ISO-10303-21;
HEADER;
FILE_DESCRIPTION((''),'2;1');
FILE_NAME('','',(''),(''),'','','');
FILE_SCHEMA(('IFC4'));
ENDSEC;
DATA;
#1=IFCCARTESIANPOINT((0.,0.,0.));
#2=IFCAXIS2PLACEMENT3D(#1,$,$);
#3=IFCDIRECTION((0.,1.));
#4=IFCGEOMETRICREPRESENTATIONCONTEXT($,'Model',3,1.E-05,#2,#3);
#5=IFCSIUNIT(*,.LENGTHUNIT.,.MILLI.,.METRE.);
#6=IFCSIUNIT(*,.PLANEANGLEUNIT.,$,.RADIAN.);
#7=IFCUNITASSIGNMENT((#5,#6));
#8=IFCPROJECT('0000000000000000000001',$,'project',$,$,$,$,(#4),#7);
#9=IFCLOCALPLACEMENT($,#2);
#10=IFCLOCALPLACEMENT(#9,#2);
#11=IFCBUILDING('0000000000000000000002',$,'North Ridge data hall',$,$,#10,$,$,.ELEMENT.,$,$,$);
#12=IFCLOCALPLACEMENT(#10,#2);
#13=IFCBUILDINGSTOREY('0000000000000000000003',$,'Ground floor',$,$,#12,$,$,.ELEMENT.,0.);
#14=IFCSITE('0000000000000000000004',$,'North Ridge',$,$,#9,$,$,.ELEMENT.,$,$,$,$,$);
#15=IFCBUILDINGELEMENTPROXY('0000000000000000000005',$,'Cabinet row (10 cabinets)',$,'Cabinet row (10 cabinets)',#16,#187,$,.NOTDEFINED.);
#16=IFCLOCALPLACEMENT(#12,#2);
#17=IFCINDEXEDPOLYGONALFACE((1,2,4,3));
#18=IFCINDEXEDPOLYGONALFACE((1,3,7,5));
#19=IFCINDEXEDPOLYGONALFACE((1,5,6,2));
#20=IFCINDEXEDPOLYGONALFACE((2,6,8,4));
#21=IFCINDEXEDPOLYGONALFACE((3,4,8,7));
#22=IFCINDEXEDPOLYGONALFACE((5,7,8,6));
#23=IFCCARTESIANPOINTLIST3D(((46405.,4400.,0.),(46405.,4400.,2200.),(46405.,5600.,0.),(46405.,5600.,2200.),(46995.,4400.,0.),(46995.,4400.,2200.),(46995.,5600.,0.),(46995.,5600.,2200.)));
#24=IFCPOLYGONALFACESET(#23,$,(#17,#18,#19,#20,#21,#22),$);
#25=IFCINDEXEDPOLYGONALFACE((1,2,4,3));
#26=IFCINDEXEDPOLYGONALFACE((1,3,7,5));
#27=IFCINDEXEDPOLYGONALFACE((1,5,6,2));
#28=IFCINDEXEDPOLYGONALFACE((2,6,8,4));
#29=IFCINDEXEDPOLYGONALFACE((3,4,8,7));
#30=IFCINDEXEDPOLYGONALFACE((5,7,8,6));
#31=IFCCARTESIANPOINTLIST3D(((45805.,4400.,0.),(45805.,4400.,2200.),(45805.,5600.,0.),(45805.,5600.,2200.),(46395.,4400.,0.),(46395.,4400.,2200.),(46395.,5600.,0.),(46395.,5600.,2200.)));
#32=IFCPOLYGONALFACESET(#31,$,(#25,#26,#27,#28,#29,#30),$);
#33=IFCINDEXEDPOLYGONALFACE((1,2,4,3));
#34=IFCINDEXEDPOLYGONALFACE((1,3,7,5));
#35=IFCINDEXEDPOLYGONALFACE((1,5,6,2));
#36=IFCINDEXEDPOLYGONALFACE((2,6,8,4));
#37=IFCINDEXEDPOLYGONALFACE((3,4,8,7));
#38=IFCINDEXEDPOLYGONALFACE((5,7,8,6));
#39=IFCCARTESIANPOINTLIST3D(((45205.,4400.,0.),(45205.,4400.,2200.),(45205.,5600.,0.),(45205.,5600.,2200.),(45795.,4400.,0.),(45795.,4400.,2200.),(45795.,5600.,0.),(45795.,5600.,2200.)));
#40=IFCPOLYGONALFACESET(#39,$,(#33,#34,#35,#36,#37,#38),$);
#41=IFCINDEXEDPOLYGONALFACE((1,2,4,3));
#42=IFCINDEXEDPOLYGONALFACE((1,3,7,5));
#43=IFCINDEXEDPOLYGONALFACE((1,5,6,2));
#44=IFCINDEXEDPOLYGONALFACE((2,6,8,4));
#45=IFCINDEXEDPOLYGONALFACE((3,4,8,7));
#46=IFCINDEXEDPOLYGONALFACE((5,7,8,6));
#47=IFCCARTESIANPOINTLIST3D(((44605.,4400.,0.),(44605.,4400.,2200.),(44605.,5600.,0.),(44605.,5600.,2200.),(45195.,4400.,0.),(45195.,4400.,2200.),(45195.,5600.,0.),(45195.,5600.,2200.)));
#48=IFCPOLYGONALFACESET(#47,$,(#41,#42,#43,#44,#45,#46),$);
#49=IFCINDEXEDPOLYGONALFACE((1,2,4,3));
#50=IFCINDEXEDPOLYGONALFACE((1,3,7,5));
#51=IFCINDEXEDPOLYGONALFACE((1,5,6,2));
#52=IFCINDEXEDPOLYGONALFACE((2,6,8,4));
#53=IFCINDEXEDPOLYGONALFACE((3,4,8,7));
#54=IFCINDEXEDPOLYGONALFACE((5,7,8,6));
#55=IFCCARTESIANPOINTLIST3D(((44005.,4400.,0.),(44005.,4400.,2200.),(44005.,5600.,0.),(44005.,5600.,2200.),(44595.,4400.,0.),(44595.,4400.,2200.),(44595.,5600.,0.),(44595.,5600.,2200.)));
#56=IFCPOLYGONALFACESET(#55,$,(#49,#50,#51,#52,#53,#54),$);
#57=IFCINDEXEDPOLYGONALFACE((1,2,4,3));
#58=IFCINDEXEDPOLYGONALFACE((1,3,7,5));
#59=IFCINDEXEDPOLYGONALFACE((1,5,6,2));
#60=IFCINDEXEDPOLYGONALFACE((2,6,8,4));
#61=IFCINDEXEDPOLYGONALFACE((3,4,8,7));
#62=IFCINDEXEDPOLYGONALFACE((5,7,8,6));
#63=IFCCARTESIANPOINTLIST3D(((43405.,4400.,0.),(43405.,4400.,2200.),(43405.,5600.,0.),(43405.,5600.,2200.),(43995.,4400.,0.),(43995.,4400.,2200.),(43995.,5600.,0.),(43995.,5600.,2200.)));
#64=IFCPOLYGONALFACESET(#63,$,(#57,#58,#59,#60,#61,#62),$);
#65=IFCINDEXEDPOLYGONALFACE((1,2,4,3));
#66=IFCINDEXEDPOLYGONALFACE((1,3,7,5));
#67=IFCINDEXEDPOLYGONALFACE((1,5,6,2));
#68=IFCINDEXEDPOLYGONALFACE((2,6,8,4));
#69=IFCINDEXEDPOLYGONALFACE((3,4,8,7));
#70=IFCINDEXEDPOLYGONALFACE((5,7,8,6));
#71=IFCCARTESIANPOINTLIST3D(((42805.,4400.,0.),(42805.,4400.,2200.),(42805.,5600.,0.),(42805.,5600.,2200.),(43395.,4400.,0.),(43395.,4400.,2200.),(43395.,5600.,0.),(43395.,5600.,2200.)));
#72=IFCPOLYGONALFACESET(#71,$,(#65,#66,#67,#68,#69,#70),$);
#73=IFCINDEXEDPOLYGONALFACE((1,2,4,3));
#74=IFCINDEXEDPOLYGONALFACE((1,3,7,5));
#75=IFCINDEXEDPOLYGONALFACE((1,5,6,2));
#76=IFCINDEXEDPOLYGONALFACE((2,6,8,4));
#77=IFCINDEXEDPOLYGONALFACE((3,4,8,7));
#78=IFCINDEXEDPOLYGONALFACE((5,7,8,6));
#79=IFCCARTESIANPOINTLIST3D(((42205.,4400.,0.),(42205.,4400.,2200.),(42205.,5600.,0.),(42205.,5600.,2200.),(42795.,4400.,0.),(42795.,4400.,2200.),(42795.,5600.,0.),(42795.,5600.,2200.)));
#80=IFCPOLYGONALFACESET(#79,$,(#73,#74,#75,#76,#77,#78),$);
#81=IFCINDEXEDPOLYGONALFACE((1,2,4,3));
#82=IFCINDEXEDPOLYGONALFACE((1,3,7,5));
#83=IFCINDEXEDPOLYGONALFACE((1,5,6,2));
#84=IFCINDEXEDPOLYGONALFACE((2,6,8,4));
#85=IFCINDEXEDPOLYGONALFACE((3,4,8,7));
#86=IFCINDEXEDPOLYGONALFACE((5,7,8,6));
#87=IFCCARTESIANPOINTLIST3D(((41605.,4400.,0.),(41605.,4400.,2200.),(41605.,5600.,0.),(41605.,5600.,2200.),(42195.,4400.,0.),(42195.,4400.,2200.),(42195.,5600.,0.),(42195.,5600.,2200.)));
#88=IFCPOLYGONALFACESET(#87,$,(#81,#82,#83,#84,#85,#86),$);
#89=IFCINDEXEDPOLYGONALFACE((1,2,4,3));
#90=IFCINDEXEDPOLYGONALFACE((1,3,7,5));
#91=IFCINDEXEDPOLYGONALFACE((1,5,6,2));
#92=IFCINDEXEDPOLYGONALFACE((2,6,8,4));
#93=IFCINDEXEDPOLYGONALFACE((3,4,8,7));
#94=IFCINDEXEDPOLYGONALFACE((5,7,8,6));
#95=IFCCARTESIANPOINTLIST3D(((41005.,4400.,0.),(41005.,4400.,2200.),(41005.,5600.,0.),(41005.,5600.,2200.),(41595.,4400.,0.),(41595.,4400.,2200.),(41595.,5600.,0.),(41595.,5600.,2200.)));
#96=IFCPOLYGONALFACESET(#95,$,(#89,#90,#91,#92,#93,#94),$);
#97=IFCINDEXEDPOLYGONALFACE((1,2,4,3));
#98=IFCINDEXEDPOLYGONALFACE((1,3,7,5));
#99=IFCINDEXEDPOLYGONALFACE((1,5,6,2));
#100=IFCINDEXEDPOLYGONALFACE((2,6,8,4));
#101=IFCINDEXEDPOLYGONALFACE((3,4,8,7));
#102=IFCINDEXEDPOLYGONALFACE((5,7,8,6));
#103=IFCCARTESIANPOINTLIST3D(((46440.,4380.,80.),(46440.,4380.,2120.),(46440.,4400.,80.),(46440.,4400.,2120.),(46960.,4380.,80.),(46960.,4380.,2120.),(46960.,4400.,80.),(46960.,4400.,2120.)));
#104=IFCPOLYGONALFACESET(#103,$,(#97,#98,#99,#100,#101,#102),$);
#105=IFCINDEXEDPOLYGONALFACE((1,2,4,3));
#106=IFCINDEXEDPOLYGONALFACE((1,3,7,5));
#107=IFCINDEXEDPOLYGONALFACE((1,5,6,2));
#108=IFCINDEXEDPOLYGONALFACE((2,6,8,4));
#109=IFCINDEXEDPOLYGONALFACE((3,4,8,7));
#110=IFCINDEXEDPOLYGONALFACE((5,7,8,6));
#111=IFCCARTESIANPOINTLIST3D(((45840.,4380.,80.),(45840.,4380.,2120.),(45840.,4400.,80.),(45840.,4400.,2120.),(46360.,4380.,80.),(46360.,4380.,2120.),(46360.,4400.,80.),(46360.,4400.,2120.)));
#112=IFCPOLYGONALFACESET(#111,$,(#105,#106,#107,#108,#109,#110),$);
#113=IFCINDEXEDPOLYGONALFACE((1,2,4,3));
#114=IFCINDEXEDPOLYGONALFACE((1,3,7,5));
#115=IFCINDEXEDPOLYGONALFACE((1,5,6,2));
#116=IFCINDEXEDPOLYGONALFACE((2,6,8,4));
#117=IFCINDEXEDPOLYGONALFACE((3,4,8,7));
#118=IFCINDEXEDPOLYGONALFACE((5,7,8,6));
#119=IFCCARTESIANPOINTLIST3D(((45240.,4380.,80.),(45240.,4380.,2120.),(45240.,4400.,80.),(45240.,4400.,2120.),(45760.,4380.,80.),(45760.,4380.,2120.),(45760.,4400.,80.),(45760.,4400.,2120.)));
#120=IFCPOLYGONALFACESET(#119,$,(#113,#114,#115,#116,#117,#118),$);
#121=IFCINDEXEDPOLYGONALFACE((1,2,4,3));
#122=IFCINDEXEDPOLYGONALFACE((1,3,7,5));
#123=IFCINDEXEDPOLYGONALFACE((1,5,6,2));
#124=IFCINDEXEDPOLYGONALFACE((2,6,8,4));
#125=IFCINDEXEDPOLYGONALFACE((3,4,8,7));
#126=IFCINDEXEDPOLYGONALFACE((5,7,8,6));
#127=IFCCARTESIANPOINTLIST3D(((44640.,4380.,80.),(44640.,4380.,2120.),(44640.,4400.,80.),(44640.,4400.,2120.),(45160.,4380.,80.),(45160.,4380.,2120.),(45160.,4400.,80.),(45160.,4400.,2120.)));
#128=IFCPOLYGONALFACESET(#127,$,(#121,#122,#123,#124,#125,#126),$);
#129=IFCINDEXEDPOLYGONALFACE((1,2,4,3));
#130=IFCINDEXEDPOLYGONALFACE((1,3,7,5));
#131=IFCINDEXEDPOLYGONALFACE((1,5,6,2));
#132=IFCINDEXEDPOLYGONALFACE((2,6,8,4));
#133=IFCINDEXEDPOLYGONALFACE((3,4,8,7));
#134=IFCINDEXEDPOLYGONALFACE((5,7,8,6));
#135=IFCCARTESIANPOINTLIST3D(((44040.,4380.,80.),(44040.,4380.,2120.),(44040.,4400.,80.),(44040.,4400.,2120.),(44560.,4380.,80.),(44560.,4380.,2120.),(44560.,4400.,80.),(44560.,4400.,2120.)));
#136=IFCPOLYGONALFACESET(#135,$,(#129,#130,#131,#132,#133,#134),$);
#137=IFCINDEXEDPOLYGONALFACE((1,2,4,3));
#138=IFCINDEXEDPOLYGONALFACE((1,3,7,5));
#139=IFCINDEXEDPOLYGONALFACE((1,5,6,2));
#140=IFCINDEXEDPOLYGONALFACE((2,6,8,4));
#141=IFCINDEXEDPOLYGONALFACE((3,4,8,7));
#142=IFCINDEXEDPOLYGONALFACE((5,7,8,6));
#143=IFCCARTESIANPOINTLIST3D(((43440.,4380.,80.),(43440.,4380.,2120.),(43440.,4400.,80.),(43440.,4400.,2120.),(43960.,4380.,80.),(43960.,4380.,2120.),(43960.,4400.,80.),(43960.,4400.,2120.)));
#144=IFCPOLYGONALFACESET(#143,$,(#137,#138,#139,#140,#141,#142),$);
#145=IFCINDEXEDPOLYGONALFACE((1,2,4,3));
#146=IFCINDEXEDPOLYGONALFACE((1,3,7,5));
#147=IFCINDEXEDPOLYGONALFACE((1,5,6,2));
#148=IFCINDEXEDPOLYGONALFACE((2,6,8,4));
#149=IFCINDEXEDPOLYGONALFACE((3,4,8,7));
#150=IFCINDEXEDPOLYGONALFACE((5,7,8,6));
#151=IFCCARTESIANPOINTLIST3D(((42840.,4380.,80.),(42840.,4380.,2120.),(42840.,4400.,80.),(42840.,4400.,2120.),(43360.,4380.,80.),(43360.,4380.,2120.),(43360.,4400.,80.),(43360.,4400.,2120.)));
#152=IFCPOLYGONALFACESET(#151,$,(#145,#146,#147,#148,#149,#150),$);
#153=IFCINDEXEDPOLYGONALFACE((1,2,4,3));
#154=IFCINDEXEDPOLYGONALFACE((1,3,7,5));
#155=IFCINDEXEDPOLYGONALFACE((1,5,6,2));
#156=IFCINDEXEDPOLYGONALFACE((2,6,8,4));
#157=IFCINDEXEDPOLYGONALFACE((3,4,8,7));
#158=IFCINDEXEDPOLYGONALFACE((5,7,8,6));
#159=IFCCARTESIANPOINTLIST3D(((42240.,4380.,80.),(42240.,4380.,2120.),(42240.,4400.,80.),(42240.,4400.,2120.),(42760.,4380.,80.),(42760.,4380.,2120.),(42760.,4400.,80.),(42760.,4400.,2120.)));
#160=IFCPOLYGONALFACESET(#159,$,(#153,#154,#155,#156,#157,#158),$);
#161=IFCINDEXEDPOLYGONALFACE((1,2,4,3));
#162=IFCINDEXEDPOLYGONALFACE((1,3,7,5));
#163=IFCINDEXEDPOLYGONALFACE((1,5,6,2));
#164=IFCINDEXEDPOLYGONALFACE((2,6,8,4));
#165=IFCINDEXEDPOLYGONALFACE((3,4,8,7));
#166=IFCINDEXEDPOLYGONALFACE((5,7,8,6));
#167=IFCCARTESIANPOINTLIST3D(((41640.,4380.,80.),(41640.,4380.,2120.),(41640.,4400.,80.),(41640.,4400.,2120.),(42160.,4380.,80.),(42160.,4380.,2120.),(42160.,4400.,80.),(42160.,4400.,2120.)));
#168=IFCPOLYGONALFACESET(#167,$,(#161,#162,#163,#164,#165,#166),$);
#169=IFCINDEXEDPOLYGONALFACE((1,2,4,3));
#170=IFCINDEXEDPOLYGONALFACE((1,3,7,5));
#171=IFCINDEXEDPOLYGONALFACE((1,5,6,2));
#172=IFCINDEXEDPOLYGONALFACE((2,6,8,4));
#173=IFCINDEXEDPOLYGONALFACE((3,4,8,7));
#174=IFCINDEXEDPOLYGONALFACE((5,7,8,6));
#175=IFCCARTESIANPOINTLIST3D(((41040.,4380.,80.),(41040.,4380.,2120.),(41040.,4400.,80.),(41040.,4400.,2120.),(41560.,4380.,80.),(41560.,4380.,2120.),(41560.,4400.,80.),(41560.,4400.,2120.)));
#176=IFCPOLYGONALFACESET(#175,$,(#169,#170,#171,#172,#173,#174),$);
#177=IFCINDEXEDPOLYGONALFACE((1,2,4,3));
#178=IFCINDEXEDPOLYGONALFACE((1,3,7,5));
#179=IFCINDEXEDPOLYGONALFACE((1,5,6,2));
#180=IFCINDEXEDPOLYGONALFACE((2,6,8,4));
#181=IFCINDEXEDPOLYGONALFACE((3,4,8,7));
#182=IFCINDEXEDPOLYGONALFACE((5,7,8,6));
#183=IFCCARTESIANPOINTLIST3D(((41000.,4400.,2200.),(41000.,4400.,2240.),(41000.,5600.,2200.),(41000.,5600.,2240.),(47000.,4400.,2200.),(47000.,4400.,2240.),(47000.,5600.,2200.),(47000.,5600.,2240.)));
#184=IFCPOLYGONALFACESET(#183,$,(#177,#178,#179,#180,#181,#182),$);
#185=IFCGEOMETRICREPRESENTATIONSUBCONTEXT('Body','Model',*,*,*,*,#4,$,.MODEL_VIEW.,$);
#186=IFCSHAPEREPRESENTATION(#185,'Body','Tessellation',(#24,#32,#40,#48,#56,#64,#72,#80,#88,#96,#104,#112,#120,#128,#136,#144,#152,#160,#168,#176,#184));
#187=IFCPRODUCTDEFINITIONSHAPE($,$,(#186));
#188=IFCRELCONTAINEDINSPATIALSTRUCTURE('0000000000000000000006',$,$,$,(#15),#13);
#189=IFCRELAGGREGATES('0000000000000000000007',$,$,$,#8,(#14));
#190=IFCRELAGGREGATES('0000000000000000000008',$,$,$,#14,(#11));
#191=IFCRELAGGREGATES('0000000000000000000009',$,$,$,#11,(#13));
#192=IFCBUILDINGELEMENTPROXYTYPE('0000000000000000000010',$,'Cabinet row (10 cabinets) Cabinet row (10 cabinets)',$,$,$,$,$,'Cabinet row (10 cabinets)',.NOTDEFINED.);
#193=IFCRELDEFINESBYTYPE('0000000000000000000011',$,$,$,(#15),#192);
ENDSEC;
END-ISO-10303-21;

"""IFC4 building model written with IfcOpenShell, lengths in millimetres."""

from ifc_helpers import new_model, si_unit, direction, frame, origin, place, context, subcontext, project, spatial, polyline, outline, extrude, source, transform, mapped, type_object, type_shapes, element, save


model = new_model("IFC4")

# Units and contexts
model_context = context("Model", 3, precision=1e-05, world=origin(), true_north=direction((0.0, 1.0)))
body_context = subcontext(model_context, "Body", "Model", "MODEL_VIEW")
ifc_project = project(units=[si_unit("LENGTHUNIT", "METRE", prefix="MILLI"), si_unit("PLANEANGLEUNIT", "RADIAN")], contexts=[model_context])

# Site, building, storey
site_placement = place(None, origin())
site = spatial("IfcSite", under=ifc_project, at=site_placement, Name="North Ridge", CompositionType="ELEMENT")
building_placement = place(site_placement, origin())
building = spatial("IfcBuilding", under=site, at=building_placement, Name="North Ridge data hall", CompositionType="ELEMENT")
storey_placement = place(building_placement, origin())
storey = spatial("IfcBuildingStorey", under=building, at=storey_placement, Name="Ground floor", CompositionType="ELEMENT", Elevation=0.0)

# Building element proxy
building_element_proxy_type_1 = type_object("IfcBuildingElementProxyType", Name="Cabinet row (10 cabinets) Cabinet row (10 cabinets)", ElementType="Cabinet row (10 cabinets)", PredefinedType="NOTDEFINED")
shared_shape_1 = source(origin(), body_context, "Body", "SweptSolid", [
    extrude(outline(polyline([(5.0, 0.0), (595.0, 0.0), (595.0, 1200.0), (5.0, 1200.0), (5.0, 0.0)])), origin(), (0.0, 0.0, 1.0), 2200.0),
    extrude(outline(polyline([(605.0, 0.0), (1195.0, 0.0), (1195.0, 1200.0), (605.0, 1200.0), (605.0, 0.0)])), origin(), (0.0, 0.0, 1.0), 2200.0),
    extrude(outline(polyline([(1205.0, 0.0), (1795.0, 0.0), (1795.0, 1200.0), (1205.0, 1200.0), (1205.0, 0.0)])), origin(), (0.0, 0.0, 1.0), 2200.0),
    extrude(outline(polyline([(1805.0, 0.0), (2395.0, 0.0), (2395.0, 1200.0), (1805.0, 1200.0), (1805.0, 0.0)])), origin(), (0.0, 0.0, 1.0), 2200.0),
    extrude(outline(polyline([(2405.0, 0.0), (2995.0, 0.0), (2995.0, 1200.0), (2405.0, 1200.0), (2405.0, 0.0)])), origin(), (0.0, 0.0, 1.0), 2200.0),
    extrude(outline(polyline([(3005.0, 0.0), (3595.0, 0.0), (3595.0, 1200.0), (3005.0, 1200.0), (3005.0, 0.0)])), origin(), (0.0, 0.0, 1.0), 2200.0),
    extrude(outline(polyline([(3605.0, 0.0), (4195.0, 0.0), (4195.0, 1200.0), (3605.0, 1200.0), (3605.0, 0.0)])), origin(), (0.0, 0.0, 1.0), 2200.0),
    extrude(outline(polyline([(4205.0, 0.0), (4795.0, 0.0), (4795.0, 1200.0), (4205.0, 1200.0), (4205.0, 0.0)])), origin(), (0.0, 0.0, 1.0), 2200.0),
    extrude(outline(polyline([(4805.0, 0.0), (5395.0, 0.0), (5395.0, 1200.0), (4805.0, 1200.0), (4805.0, 0.0)])), origin(), (0.0, 0.0, 1.0), 2200.0),
    extrude(outline(polyline([(5405.0, 0.0), (5995.0, 0.0), (5995.0, 1200.0), (5405.0, 1200.0), (5405.0, 0.0)])), origin(), (0.0, 0.0, 1.0), 2200.0),
    extrude(outline(polyline([(40.0, 1200.0), (560.0, 1200.0), (560.0, 1220.0), (40.0, 1220.0), (40.0, 1200.0)])), frame((0.0, 0.0, 80.0)), (0.0, 0.0, 1.0), 2040.0),
    extrude(outline(polyline([(640.0, 1200.0), (1160.0, 1200.0), (1160.0, 1220.0), (640.0, 1220.0), (640.0, 1200.0)])), frame((0.0, 0.0, 80.0)), (0.0, 0.0, 1.0), 2040.0),
    extrude(outline(polyline([(1240.0, 1200.0), (1760.0, 1200.0), (1760.0, 1220.0), (1240.0, 1220.0), (1240.0, 1200.0)])), frame((0.0, 0.0, 80.0)), (0.0, 0.0, 1.0), 2040.0),
    extrude(outline(polyline([(1840.0, 1200.0), (2360.0, 1200.0), (2360.0, 1220.0), (1840.0, 1220.0), (1840.0, 1200.0)])), frame((0.0, 0.0, 80.0)), (0.0, 0.0, 1.0), 2040.0),
    extrude(outline(polyline([(2440.0, 1200.0), (2960.0, 1200.0), (2960.0, 1220.0), (2440.0, 1220.0), (2440.0, 1200.0)])), frame((0.0, 0.0, 80.0)), (0.0, 0.0, 1.0), 2040.0),
    extrude(outline(polyline([(3040.0, 1200.0), (3560.0, 1200.0), (3560.0, 1220.0), (3040.0, 1220.0), (3040.0, 1200.0)])), frame((0.0, 0.0, 80.0)), (0.0, 0.0, 1.0), 2040.0),
    extrude(outline(polyline([(3640.0, 1200.0), (4160.0, 1200.0), (4160.0, 1220.0), (3640.0, 1220.0), (3640.0, 1200.0)])), frame((0.0, 0.0, 80.0)), (0.0, 0.0, 1.0), 2040.0),
    extrude(outline(polyline([(4240.0, 1200.0), (4760.0, 1200.0), (4760.0, 1220.0), (4240.0, 1220.0), (4240.0, 1200.0)])), frame((0.0, 0.0, 80.0)), (0.0, 0.0, 1.0), 2040.0),
    extrude(outline(polyline([(4840.0, 1200.0), (5360.0, 1200.0), (5360.0, 1220.0), (4840.0, 1220.0), (4840.0, 1200.0)])), frame((0.0, 0.0, 80.0)), (0.0, 0.0, 1.0), 2040.0),
    extrude(outline(polyline([(5440.0, 1200.0), (5960.0, 1200.0), (5960.0, 1220.0), (5440.0, 1220.0), (5440.0, 1200.0)])), frame((0.0, 0.0, 80.0)), (0.0, 0.0, 1.0), 2040.0),
    extrude(outline(polyline([(0.0, 0.0), (6000.0, 0.0), (6000.0, 1200.0), (0.0, 1200.0), (0.0, 0.0)])), frame((0.0, 0.0, 2200.0)), (0.0, 0.0, 1.0), 40.0),
])
type_shapes(building_element_proxy_type_1, [shared_shape_1])
for number, where, z_axis, x_axis, name in (
    (1, (47000.0, 5600.0, 0.0), (0.0, 0.0, 1.0), (-1.0, 0.0, 0.0), "Cabinet row (10 cabinets)"),
):
    element("IfcBuildingElementProxy", number, at=place(storey_placement, frame(where, z_axis=z_axis, x_axis=x_axis)), inside=storey, type_object=building_element_proxy_type_1, Name=name, ObjectType="Cabinet row (10 cabinets)", PredefinedType="NOTDEFINED", context=body_context, shape_type="MappedRepresentation", body=[
        mapped(shared_shape_1, transform((0.0, 0.0, 0.0))),
    ])

save(model, "model.ifc")
